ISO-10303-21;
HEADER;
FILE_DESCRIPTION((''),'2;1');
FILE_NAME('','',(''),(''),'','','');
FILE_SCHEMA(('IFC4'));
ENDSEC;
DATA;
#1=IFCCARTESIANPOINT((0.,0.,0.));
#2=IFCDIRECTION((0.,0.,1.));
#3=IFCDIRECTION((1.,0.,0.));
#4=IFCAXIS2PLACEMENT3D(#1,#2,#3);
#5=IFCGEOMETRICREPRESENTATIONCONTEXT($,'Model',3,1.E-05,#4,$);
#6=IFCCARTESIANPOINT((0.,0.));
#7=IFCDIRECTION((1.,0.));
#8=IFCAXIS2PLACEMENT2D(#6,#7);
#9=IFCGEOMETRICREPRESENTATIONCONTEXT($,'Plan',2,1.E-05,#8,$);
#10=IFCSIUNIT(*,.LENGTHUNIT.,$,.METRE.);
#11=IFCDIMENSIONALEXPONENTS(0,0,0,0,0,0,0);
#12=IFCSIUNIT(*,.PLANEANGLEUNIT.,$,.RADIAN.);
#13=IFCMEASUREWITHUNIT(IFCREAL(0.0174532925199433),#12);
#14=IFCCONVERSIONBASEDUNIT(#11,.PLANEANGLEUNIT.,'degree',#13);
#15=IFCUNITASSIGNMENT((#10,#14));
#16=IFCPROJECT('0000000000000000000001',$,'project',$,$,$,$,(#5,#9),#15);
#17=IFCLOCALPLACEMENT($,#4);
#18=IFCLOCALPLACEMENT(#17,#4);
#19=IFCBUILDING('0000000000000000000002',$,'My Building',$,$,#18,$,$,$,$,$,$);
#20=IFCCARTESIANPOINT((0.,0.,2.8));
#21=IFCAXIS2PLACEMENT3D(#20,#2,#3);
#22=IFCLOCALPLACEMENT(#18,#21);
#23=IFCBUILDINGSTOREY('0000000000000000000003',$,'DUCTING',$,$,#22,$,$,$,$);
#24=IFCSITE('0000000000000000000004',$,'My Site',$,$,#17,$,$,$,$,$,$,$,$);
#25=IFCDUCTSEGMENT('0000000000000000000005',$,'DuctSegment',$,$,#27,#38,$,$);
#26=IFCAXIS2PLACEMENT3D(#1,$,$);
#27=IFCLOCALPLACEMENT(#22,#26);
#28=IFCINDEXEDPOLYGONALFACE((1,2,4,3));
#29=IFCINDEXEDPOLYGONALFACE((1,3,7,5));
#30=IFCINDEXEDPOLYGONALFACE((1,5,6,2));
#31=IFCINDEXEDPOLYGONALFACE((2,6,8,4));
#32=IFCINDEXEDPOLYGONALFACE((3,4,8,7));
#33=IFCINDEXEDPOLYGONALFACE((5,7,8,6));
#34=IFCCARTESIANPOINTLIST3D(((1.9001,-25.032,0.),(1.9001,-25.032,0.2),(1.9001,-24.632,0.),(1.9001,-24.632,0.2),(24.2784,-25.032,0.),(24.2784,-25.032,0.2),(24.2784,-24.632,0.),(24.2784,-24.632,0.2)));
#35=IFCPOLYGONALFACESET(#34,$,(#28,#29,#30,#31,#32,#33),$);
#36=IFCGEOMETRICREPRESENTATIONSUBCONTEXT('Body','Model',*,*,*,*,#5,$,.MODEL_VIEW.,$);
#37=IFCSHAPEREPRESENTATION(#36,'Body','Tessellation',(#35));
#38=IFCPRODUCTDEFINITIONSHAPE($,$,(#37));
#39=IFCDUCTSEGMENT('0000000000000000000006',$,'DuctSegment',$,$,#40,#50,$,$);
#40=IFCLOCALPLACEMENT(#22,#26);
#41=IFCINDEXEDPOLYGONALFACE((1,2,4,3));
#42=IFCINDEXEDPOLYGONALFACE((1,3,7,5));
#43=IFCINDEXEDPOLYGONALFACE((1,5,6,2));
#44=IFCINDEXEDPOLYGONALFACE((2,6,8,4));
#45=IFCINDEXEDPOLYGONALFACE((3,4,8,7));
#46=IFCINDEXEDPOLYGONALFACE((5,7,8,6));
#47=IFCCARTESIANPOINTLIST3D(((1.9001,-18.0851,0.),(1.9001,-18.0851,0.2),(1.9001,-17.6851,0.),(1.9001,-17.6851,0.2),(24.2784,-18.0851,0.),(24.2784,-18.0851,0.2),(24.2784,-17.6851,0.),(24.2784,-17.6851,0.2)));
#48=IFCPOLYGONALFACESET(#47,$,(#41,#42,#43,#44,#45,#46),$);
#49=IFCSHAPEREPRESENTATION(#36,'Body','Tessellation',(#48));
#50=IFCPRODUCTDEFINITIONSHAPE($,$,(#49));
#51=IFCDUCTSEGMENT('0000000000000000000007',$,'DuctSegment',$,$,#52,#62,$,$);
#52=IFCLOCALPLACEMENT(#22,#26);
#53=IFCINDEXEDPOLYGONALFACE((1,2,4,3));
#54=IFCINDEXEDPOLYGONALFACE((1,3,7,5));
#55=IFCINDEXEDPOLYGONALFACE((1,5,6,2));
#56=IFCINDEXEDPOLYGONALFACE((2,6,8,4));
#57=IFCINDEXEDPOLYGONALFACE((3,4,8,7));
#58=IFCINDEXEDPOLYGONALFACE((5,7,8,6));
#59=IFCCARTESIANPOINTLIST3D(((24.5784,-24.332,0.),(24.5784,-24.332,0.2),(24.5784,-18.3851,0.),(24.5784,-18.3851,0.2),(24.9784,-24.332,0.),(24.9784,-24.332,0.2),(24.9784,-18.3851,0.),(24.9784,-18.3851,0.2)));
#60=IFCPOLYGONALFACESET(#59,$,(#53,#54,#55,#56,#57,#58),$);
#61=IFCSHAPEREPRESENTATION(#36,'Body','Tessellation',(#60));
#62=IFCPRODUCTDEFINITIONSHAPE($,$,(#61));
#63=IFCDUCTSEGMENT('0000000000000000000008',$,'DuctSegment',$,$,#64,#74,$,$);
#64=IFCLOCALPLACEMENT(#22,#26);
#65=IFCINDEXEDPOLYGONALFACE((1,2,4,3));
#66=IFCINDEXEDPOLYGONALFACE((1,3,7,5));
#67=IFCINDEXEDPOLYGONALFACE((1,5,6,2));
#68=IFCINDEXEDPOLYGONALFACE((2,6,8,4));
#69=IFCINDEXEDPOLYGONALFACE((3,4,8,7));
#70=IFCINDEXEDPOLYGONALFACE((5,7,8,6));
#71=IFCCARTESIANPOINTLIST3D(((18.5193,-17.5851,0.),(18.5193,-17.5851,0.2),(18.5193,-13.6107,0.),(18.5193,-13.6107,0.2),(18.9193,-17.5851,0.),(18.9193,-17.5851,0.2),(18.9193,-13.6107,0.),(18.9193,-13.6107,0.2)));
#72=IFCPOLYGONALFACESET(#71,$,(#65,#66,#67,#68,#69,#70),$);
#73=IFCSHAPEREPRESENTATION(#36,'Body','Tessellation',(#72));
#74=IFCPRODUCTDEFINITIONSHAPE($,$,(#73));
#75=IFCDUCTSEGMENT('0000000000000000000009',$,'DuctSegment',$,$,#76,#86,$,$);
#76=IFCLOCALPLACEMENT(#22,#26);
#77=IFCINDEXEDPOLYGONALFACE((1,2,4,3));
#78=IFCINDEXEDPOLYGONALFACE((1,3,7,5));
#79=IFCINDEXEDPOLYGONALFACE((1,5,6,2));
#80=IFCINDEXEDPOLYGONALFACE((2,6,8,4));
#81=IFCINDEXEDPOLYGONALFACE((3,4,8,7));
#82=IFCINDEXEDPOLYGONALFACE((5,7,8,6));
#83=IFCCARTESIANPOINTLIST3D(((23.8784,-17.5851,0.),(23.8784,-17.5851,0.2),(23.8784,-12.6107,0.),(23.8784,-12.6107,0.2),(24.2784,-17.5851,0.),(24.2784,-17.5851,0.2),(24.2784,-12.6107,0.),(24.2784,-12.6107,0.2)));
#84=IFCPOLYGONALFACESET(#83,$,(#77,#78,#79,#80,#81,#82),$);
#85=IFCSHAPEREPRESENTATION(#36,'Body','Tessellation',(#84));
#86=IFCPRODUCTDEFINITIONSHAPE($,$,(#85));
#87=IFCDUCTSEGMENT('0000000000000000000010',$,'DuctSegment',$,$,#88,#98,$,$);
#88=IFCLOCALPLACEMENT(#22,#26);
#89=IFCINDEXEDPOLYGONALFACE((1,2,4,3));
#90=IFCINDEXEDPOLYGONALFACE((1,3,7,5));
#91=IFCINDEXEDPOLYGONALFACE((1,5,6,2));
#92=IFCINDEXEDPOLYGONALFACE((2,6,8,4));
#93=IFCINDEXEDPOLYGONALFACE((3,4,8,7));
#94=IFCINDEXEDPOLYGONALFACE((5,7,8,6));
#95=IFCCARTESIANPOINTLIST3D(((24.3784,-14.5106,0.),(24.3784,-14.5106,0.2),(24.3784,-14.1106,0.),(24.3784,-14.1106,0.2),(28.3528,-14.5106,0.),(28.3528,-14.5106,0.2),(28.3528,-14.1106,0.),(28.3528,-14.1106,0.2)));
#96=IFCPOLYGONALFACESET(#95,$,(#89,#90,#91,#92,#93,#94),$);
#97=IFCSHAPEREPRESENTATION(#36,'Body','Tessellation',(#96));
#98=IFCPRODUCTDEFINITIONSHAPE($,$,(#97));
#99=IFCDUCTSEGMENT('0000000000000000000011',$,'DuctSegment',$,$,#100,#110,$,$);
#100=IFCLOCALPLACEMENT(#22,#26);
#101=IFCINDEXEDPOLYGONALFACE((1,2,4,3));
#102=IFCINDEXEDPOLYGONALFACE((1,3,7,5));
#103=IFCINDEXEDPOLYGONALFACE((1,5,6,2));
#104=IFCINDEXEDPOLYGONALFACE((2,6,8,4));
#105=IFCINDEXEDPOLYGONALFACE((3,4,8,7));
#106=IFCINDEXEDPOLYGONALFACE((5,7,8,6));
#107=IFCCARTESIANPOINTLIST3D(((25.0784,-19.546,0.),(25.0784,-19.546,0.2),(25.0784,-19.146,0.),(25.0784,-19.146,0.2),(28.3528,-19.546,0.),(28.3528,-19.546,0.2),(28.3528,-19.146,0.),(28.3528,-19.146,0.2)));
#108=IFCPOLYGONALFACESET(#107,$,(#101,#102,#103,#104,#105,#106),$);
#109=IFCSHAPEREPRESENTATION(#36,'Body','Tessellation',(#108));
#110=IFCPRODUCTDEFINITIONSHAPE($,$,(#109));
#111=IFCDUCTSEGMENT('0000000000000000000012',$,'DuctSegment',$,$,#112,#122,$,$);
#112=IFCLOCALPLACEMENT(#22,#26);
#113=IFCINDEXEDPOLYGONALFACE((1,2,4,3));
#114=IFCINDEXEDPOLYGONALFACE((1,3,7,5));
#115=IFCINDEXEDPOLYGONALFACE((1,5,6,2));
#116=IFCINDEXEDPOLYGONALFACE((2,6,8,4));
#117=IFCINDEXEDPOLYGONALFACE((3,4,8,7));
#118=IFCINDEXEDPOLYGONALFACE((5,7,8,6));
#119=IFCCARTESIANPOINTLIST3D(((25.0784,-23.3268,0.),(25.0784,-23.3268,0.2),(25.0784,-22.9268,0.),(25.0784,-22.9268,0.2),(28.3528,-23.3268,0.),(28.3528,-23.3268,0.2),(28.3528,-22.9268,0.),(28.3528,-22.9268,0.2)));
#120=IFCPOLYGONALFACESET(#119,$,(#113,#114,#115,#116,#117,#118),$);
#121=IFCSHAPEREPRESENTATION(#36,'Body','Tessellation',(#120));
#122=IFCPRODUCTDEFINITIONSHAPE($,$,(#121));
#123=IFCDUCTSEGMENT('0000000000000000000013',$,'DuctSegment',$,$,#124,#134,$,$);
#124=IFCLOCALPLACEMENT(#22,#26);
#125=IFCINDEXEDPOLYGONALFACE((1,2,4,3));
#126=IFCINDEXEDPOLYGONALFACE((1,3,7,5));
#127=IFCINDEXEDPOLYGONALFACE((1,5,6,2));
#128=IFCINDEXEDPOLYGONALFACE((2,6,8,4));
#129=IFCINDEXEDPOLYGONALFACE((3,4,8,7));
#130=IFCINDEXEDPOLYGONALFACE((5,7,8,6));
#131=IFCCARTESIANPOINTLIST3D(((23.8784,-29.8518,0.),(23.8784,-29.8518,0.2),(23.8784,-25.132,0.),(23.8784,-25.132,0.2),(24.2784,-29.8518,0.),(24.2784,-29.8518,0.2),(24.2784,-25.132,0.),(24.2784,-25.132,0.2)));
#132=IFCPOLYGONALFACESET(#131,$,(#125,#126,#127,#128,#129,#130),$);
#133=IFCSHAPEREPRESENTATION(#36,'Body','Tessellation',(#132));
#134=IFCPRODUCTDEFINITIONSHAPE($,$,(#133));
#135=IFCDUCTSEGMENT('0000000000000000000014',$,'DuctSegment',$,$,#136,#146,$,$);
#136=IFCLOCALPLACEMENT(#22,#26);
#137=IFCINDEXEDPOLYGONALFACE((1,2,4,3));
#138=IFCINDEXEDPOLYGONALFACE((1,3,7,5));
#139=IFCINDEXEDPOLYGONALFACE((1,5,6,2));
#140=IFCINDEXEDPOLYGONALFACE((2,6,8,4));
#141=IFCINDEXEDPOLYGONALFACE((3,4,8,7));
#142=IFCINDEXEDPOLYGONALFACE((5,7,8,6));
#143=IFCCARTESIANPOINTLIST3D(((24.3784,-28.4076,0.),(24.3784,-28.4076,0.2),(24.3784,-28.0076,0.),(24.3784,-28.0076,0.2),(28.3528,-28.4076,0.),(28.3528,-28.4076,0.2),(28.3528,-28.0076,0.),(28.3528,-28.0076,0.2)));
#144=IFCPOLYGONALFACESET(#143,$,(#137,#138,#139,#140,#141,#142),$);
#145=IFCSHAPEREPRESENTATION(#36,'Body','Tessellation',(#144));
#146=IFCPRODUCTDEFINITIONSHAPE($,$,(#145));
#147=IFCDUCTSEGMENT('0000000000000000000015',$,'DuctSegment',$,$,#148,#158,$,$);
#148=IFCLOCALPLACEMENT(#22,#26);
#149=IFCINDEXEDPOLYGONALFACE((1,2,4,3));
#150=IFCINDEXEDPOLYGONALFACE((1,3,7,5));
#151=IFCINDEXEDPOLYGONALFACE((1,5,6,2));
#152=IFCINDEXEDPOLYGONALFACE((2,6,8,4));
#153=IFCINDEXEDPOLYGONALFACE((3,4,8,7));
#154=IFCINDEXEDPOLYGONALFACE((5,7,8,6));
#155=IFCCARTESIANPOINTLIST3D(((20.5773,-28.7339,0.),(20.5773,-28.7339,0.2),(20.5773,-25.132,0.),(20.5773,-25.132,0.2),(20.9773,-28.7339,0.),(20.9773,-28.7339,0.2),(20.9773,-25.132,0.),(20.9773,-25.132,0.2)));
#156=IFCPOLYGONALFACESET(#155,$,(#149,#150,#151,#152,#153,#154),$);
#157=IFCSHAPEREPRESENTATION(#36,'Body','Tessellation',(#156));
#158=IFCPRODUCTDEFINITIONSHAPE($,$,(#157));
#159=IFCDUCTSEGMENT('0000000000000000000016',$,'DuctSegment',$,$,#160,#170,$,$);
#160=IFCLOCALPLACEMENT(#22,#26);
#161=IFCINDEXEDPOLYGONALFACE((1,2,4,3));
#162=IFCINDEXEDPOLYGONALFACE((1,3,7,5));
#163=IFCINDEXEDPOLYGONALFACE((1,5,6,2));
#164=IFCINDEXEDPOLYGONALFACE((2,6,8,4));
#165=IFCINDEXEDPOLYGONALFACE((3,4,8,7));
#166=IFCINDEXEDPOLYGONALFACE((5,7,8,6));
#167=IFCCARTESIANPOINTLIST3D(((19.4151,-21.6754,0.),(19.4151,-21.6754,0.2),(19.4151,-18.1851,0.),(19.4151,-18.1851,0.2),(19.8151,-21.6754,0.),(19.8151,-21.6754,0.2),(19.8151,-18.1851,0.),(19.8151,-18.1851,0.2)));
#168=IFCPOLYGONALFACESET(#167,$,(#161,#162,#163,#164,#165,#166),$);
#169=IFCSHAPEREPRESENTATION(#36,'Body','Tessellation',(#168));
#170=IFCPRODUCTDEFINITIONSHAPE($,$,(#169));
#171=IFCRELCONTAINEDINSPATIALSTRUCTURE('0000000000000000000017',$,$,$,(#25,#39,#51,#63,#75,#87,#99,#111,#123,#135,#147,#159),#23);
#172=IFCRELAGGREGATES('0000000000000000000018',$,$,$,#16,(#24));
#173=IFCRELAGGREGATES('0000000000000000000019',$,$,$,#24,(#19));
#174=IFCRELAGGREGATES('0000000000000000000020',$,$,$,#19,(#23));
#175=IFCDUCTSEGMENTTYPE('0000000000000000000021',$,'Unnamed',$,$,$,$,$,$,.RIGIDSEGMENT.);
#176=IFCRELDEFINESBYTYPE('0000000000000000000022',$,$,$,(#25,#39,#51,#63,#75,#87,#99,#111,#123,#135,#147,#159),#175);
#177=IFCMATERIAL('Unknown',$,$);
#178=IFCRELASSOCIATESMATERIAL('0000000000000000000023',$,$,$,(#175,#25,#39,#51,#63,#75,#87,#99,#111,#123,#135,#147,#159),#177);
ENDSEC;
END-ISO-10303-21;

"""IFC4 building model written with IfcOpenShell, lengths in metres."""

from ifc_helpers import new_model, entity, si_unit, converted_unit, frame, origin_with_axes, origin_2d_with_axis, place, context, subcontext, project, spatial, rectangle, extrude, material, material_profile, profile_set, profile_usage, type_object, element, save


model = new_model("IFC4")

# Units and contexts
model_context = context("Model", 3, precision=1e-05, world=origin_with_axes())
plan_context = context("Plan", 2, precision=1e-05, world=origin_2d_with_axis())
body_context = subcontext(model_context, "Body", "Model", "MODEL_VIEW")
ifc_project = project(units=[si_unit("LENGTHUNIT", "METRE"), converted_unit("PLANEANGLEUNIT", "degree", entity("IfcReal", 0.0174532925199433), si_unit("PLANEANGLEUNIT", "RADIAN"), dimensions=[0, 0, 0, 0, 0, 0, 0])], contexts=[model_context, plan_context])

# Site, building, storey
site_placement = place(None, origin_with_axes())
site = spatial("IfcSite", under=ifc_project, at=site_placement, Name="My Site")
building_placement = place(site_placement, origin_with_axes())
building = spatial("IfcBuilding", under=site, at=building_placement, Name="My Building")
storey_placement = place(building_placement, frame((0.0, 0.0, 2.8), z_axis=(0.0, 0.0, 1.0), x_axis=(1.0, 0.0, 0.0)))
storey = spatial("IfcBuildingStorey", under=building, at=storey_placement, Name="DUCTING")

# Duct segments
ifc_material = material(Name="Unknown")
ifc_material_profile_1 = material_profile(ifc_material, rectangle(XDim=0.4, YDim=0.2))
ifc_profile_set_1 = profile_set([ifc_material_profile_1])
ifc_profile_usage_1 = profile_usage(ifc_profile_set_1, cardinal=5)
duct_segment_type = type_object("IfcDuctSegmentType", Name="Unnamed", PredefinedType="RIGIDSEGMENT", material=ifc_profile_set_1)
duct_segment_1_placement = place(storey_placement, frame((24.2784, -24.832, 0.1), z_axis=(-1.0, 0.0, 0.000001), x_axis=(0.0, -1.0, 0.0)))
element("IfcDuctSegment", 1, at=duct_segment_1_placement, inside=storey, type_object=duct_segment_type, material=ifc_profile_usage_1, Name="DuctSegment", context=body_context, shape_type="SweptSolid", body=[
    extrude(rectangle(XDim=0.4, YDim=0.2), origin_with_axes(), (0.0, 0.0, 1.0), 22.3784),
])
ifc_profile_usage_2 = profile_usage(ifc_profile_set_1, cardinal=5)
duct_segment_2_placement = place(storey_placement, frame((24.2784, -17.8851, 0.1), z_axis=(-1.0, 0.0, 0.000001), x_axis=(0.0, -1.0, 0.0)))
element("IfcDuctSegment", 2, at=duct_segment_2_placement, inside=storey, type_object=duct_segment_type, material=ifc_profile_usage_2, Name="DuctSegment", context=body_context, shape_type="SweptSolid", body=[
    extrude(rectangle(XDim=0.4, YDim=0.2), origin_with_axes(), (0.0, 0.0, 1.0), 22.3784),
])
ifc_profile_usage_3 = profile_usage(ifc_profile_set_1, cardinal=5)
duct_segment_3_placement = place(storey_placement, frame((24.7784, -24.332, 0.1), z_axis=(0.0, 1.0, 0.0), x_axis=(-1.0, 0.0, 0.0)))
element("IfcDuctSegment", 3, at=duct_segment_3_placement, inside=storey, type_object=duct_segment_type, material=ifc_profile_usage_3, Name="DuctSegment", context=body_context, shape_type="SweptSolid", body=[
    extrude(rectangle(XDim=0.4, YDim=0.2), origin_with_axes(), (0.0, 0.0, 1.0), 5.9469),
])
ifc_profile_usage_4 = profile_usage(ifc_profile_set_1, cardinal=5)
duct_segment_4_placement = place(storey_placement, frame((18.7193, -17.5851, 0.1), z_axis=(0.0, 1.0, 0.0), x_axis=(-1.0, 0.0, 0.0)))
element("IfcDuctSegment", 4, at=duct_segment_4_placement, inside=storey, type_object=duct_segment_type, material=ifc_profile_usage_4, Name="DuctSegment", context=body_context, shape_type="SweptSolid", body=[
    extrude(rectangle(XDim=0.4, YDim=0.2), origin_with_axes(), (0.0, 0.0, 1.0), 3.9744),
])
ifc_profile_usage_5 = profile_usage(ifc_profile_set_1, cardinal=5)
duct_segment_5_placement = place(storey_placement, frame((24.0784, -17.5851, 0.1), z_axis=(0.0, 1.0, 0.0), x_axis=(-1.0, 0.0, 0.0)))
element("IfcDuctSegment", 5, at=duct_segment_5_placement, inside=storey, type_object=duct_segment_type, material=ifc_profile_usage_5, Name="DuctSegment", context=body_context, shape_type="SweptSolid", body=[
    extrude(rectangle(XDim=0.4, YDim=0.2), origin_with_axes(), (0.0, 0.0, 1.0), 4.9744),
])
ifc_profile_usage_6 = profile_usage(ifc_profile_set_1, cardinal=5)
duct_segment_6_placement = place(storey_placement, frame((24.3784, -14.3106, 0.1), z_axis=(1.0, 0.0, 0.0), x_axis=(0.0, 1.0, 0.0)))
element("IfcDuctSegment", 6, at=duct_segment_6_placement, inside=storey, type_object=duct_segment_type, material=ifc_profile_usage_6, Name="DuctSegment", context=body_context, shape_type="SweptSolid", body=[
    extrude(rectangle(XDim=0.4, YDim=0.2), origin_with_axes(), (0.0, 0.0, 1.0), 3.9744),
])
ifc_profile_usage_7 = profile_usage(ifc_profile_set_1, cardinal=5)
duct_segment_7_placement = place(storey_placement, frame((25.0784, -19.346, 0.1), z_axis=(1.0, 0.0, 0.0), x_axis=(0.0, 1.0, 0.0)))
element("IfcDuctSegment", 7, at=duct_segment_7_placement, inside=storey, type_object=duct_segment_type, material=ifc_profile_usage_7, Name="DuctSegment", context=body_context, shape_type="SweptSolid", body=[
    extrude(rectangle(XDim=0.4, YDim=0.2), origin_with_axes(), (0.0, 0.0, 1.0), 3.2744),
])
ifc_profile_usage_8 = profile_usage(ifc_profile_set_1, cardinal=5)
duct_segment_8_placement = place(storey_placement, frame((25.0784, -23.1268, 0.1), z_axis=(1.0, 0.0, 0.0), x_axis=(0.0, 1.0, 0.0)))
element("IfcDuctSegment", 8, at=duct_segment_8_placement, inside=storey, type_object=duct_segment_type, material=ifc_profile_usage_8, Name="DuctSegment", context=body_context, shape_type="SweptSolid", body=[
    extrude(rectangle(XDim=0.4, YDim=0.2), origin_with_axes(), (0.0, 0.0, 1.0), 3.2744),
])
ifc_profile_usage_9 = profile_usage(ifc_profile_set_1, cardinal=5)
duct_segment_9_placement = place(storey_placement, frame((24.0784, -25.132, 0.1), z_axis=(0.0, -1.0, 0.0), x_axis=(1.0, 0.0, 0.0)))
element("IfcDuctSegment", 9, at=duct_segment_9_placement, inside=storey, type_object=duct_segment_type, material=ifc_profile_usage_9, Name="DuctSegment", context=body_context, shape_type="SweptSolid", body=[
    extrude(rectangle(XDim=0.4, YDim=0.2), origin_with_axes(), (0.0, 0.0, 1.0), 4.7198),
])
ifc_profile_usage_10 = profile_usage(ifc_profile_set_1, cardinal=5)
duct_segment_10_placement = place(storey_placement, frame((24.3784, -28.2076, 0.1), z_axis=(1.0, 0.0, 0.0), x_axis=(0.0, 1.0, 0.0)))
element("IfcDuctSegment", 10, at=duct_segment_10_placement, inside=storey, type_object=duct_segment_type, material=ifc_profile_usage_10, Name="DuctSegment", context=body_context, shape_type="SweptSolid", body=[
    extrude(rectangle(XDim=0.4, YDim=0.2), origin_with_axes(), (0.0, 0.0, 1.0), 3.9744),
])
ifc_profile_usage_11 = profile_usage(ifc_profile_set_1, cardinal=5)
duct_segment_11_placement = place(storey_placement, frame((20.7773, -25.132, 0.1), z_axis=(0.0, -1.0, 0.0), x_axis=(1.0, 0.0, 0.0)))
element("IfcDuctSegment", 11, at=duct_segment_11_placement, inside=storey, type_object=duct_segment_type, material=ifc_profile_usage_11, Name="DuctSegment", context=body_context, shape_type="SweptSolid", body=[
    extrude(rectangle(XDim=0.4, YDim=0.2), origin_with_axes(), (0.0, 0.0, 1.0), 3.6018),
])
ifc_profile_usage_12 = profile_usage(ifc_profile_set_1, cardinal=5)
duct_segment_12_placement = place(storey_placement, frame((19.6151, -18.1851, 0.1), z_axis=(0.0, -1.0, 0.0), x_axis=(1.0, 0.0, 0.0)))
element("IfcDuctSegment", 12, at=duct_segment_12_placement, inside=storey, type_object=duct_segment_type, material=ifc_profile_usage_12, Name="DuctSegment", context=body_context, shape_type="SweptSolid", body=[
    extrude(rectangle(XDim=0.4, YDim=0.2), origin_with_axes(), (0.0, 0.0, 1.0), 3.4903),
])

save(model, "model.ifc")
